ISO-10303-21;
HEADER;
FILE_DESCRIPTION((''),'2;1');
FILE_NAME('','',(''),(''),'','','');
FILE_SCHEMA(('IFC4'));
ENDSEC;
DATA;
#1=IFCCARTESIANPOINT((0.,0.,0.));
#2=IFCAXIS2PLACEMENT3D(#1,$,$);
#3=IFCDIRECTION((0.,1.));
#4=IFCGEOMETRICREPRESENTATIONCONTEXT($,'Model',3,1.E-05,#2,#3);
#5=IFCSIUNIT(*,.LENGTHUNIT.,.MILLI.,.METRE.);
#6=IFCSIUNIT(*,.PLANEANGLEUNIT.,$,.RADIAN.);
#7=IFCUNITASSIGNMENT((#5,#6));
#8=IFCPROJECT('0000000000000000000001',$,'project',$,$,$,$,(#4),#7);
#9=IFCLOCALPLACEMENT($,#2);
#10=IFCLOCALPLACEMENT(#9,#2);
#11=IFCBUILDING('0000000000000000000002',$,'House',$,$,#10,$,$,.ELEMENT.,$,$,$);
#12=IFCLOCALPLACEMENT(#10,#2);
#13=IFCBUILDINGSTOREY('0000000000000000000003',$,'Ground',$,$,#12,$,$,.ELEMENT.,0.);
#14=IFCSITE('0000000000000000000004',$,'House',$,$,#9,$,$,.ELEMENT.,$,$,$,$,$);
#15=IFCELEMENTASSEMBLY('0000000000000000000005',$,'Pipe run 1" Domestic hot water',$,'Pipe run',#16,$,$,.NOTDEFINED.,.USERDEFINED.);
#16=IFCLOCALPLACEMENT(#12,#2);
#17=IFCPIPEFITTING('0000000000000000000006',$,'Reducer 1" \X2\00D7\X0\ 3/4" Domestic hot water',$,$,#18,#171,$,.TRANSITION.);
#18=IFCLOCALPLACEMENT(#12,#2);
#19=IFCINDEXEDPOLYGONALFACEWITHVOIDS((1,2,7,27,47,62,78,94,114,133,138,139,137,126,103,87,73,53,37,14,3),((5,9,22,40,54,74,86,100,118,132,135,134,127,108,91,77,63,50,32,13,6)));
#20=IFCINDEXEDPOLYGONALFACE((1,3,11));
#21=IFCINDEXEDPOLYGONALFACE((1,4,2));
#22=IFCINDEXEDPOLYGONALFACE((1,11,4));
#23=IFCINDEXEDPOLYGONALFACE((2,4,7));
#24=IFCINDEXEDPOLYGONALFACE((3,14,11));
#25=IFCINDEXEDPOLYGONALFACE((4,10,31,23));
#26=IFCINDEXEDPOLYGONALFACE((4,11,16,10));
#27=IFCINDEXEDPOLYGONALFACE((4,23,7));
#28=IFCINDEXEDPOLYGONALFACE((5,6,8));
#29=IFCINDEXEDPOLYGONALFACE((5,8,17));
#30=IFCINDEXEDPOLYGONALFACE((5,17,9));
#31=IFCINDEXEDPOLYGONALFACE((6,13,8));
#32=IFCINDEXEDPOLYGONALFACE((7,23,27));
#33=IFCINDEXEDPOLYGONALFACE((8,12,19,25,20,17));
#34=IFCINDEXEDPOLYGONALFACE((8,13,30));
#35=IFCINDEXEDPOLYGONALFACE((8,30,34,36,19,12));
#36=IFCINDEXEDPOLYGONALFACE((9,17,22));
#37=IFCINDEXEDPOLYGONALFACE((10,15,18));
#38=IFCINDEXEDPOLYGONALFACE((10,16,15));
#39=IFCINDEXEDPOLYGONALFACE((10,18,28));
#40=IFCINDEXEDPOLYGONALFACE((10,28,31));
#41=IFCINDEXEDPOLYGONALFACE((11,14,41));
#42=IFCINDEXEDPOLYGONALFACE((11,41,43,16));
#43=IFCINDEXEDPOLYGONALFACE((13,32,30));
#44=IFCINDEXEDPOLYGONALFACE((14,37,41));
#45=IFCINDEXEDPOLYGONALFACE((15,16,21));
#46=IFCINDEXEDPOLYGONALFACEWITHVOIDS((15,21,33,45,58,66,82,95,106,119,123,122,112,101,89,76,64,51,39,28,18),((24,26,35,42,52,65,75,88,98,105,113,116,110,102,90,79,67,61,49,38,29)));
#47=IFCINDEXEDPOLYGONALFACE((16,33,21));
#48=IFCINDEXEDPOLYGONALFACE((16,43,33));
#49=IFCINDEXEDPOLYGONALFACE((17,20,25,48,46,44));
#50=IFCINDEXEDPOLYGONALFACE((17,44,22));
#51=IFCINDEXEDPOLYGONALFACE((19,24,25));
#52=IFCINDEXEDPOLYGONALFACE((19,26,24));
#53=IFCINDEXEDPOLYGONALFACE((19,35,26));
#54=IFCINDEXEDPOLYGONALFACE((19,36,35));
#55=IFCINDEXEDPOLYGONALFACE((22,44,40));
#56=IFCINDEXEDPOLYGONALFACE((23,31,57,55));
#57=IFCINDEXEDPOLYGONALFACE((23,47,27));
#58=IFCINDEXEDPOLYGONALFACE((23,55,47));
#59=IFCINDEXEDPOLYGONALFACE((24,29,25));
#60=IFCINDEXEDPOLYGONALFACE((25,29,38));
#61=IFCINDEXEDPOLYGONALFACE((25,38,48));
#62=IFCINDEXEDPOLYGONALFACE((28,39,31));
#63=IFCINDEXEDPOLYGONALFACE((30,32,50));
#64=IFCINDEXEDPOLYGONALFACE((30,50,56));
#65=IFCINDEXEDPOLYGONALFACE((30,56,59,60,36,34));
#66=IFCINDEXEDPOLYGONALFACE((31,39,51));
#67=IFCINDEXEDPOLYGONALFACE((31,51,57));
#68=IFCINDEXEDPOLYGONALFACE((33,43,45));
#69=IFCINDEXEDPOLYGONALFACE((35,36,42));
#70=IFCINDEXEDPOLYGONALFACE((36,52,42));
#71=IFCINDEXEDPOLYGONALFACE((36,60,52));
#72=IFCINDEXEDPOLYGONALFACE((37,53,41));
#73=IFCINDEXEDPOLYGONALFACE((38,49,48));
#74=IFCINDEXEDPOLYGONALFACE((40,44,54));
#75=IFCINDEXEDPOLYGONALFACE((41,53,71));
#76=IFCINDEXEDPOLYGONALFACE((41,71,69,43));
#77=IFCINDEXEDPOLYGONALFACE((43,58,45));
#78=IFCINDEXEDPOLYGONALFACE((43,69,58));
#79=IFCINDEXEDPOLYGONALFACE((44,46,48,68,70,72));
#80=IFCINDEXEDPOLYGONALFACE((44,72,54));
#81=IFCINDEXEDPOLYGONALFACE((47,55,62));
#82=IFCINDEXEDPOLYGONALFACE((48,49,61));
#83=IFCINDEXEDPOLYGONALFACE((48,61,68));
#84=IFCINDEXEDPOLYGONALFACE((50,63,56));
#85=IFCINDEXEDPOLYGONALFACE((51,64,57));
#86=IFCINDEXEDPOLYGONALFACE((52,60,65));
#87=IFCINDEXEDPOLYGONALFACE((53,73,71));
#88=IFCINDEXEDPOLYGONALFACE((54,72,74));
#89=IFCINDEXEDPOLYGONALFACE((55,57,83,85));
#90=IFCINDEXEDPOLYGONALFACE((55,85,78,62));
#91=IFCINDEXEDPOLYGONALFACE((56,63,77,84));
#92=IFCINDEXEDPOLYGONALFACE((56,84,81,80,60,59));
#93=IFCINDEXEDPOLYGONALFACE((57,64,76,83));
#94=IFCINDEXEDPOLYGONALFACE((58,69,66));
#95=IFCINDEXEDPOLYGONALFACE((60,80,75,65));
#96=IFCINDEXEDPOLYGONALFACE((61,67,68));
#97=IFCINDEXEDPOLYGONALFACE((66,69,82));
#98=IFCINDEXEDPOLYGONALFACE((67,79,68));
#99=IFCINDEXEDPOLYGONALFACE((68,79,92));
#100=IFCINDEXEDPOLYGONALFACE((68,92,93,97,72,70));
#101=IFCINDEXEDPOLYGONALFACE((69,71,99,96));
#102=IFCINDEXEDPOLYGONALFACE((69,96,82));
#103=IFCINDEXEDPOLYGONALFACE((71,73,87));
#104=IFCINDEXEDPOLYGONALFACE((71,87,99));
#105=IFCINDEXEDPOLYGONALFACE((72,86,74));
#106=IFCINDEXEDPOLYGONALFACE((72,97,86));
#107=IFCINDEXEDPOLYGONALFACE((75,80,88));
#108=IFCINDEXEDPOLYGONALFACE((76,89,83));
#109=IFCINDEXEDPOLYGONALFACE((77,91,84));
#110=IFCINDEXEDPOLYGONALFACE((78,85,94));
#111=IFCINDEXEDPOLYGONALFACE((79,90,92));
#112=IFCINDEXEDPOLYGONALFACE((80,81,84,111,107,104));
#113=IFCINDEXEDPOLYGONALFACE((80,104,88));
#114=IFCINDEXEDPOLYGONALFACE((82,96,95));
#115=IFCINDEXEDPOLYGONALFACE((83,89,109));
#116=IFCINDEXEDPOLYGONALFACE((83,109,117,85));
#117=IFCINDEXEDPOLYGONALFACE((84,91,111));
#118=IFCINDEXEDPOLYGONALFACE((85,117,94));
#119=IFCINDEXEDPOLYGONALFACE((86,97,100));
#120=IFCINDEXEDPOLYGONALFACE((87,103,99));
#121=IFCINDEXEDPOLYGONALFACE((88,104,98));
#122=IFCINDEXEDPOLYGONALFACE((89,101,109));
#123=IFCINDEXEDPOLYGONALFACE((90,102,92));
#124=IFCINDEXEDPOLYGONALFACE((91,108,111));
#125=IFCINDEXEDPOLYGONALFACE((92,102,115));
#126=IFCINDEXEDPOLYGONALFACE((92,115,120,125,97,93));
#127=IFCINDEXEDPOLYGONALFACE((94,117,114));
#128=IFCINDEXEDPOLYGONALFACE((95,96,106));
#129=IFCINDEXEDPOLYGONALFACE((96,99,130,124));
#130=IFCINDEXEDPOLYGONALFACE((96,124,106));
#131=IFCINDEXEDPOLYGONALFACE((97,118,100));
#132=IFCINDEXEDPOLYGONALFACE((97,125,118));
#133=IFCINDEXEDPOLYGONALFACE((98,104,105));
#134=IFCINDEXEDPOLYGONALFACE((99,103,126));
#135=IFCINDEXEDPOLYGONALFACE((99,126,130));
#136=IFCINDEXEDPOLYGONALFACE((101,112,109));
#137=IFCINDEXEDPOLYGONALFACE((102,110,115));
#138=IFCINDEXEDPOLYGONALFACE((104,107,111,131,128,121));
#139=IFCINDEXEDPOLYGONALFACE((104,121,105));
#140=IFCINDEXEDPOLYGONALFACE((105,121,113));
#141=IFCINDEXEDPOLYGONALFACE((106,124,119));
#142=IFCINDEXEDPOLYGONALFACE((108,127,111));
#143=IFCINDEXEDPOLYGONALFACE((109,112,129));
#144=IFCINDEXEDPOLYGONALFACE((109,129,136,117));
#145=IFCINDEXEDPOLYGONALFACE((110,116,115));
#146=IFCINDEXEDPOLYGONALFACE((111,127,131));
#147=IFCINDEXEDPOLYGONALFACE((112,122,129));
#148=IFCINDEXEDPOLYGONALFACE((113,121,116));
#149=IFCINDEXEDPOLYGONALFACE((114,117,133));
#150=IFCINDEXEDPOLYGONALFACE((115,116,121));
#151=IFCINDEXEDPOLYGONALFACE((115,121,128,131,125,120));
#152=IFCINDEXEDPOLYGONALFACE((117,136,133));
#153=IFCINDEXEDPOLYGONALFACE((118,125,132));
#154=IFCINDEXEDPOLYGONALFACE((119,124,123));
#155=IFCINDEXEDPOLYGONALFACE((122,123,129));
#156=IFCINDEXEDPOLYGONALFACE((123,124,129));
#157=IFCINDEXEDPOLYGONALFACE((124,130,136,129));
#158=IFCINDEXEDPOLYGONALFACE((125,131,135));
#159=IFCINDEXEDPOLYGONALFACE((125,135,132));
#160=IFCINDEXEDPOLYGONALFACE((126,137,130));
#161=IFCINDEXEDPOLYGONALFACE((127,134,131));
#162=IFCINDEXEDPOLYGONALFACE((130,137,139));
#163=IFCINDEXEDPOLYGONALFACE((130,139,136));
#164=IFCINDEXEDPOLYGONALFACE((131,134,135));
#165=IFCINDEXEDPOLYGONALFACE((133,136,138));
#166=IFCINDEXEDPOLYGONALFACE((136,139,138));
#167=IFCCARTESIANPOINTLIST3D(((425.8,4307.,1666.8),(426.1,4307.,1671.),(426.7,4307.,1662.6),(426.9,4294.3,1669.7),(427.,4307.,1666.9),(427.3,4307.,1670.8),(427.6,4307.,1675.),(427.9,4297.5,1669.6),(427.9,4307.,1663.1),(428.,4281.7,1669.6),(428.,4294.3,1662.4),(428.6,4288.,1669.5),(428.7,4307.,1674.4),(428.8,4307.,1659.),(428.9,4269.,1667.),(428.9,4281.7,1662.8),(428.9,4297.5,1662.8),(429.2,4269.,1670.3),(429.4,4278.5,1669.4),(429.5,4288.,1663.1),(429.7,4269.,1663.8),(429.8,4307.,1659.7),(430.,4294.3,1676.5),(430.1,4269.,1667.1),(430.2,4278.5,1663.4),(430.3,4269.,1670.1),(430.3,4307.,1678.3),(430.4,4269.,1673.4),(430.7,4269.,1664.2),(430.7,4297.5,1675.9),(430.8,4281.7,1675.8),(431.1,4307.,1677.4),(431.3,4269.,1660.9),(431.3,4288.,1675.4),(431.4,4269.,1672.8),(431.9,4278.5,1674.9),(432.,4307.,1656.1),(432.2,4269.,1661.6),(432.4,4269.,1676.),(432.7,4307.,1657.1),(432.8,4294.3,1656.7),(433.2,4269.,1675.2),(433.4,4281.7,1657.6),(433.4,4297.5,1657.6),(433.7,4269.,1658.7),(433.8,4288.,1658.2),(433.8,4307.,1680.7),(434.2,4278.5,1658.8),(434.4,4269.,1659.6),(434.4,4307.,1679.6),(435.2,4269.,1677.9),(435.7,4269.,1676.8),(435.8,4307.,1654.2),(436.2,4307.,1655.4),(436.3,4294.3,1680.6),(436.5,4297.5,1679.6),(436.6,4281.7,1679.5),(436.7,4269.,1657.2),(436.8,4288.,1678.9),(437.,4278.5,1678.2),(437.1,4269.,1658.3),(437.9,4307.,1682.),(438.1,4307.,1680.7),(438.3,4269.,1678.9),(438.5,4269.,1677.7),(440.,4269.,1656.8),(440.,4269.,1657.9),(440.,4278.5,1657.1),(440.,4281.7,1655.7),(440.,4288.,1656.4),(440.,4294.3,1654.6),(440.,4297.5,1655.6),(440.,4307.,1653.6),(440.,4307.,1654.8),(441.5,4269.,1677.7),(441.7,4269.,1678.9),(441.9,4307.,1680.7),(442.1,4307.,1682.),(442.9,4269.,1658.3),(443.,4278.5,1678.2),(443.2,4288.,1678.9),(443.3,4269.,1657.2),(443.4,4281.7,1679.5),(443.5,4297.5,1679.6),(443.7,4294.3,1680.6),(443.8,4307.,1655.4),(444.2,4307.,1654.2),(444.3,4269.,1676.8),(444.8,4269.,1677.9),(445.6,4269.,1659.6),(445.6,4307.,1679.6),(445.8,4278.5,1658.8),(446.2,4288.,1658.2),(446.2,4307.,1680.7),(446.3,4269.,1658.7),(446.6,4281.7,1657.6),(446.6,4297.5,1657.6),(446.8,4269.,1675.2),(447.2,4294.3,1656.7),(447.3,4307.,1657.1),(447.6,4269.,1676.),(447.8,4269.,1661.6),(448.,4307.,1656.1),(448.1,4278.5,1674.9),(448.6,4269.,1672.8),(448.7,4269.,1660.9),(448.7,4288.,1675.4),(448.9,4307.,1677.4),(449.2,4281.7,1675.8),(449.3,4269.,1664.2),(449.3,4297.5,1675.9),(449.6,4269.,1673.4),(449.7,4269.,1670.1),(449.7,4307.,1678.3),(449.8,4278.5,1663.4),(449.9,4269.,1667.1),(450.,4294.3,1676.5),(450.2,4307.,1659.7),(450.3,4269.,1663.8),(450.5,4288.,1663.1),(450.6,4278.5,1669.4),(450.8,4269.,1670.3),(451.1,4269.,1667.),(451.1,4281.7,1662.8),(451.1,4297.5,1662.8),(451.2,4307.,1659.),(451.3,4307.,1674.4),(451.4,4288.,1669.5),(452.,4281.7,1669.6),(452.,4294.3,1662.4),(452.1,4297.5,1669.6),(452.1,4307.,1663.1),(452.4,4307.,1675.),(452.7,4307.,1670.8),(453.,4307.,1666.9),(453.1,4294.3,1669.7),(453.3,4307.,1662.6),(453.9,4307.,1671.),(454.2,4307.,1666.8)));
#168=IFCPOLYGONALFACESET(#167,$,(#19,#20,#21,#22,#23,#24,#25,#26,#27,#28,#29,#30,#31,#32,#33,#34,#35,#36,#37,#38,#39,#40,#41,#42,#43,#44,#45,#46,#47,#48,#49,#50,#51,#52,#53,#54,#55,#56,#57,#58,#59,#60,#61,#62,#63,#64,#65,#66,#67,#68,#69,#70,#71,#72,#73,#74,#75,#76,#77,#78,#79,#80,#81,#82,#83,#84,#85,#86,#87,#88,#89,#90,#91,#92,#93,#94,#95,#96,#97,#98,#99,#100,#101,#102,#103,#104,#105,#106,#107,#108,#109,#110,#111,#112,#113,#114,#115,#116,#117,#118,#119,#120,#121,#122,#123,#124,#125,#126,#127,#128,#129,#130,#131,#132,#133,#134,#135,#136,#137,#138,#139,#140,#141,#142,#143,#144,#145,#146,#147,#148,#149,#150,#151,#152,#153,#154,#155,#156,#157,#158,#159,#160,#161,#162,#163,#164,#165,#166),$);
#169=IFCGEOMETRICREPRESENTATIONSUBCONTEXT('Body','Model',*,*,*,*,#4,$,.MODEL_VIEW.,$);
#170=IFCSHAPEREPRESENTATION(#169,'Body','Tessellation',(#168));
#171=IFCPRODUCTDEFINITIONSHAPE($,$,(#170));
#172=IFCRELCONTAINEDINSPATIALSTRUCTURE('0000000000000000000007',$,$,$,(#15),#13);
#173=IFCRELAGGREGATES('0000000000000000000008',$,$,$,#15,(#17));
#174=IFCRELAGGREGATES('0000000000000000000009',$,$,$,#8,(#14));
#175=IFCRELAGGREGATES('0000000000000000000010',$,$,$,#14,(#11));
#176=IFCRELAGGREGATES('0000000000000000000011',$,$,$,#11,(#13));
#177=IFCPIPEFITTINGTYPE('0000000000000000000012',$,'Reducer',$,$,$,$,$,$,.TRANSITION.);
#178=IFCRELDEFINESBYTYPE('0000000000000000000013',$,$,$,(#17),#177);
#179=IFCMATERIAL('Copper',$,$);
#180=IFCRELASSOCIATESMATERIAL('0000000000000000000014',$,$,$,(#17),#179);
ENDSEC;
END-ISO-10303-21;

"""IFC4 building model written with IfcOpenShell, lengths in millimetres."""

from ifc_helpers import new_model, entity, si_unit, direction, origin, origin_with_axes, place, context, subcontext, project, spatial, material, type_object, element, aggregate, save


model = new_model("IFC4")

# Units and contexts
model_context = context("Model", 3, precision=1e-05, world=origin(), true_north=direction((0.0, 1.0)))
body_context = subcontext(model_context, "Body", "Model", "MODEL_VIEW")
ifc_project = project(units=[si_unit("LENGTHUNIT", "METRE", prefix="MILLI"), si_unit("PLANEANGLEUNIT", "RADIAN")], contexts=[model_context])

# Site, building, storey
site_placement = place(None, origin())
site = spatial("IfcSite", under=ifc_project, at=site_placement, Name="House", CompositionType="ELEMENT")
building_placement = place(site_placement, origin())
building = spatial("IfcBuilding", under=site, at=building_placement, Name="House", CompositionType="ELEMENT")
storey_placement = place(building_placement, origin())
storey = spatial("IfcBuildingStorey", under=building, at=storey_placement, Name="Ground", CompositionType="ELEMENT", Elevation=0.0)

# Element assembly
assembly_1_placement = place(storey_placement, origin_with_axes())
assembly_1 = element("IfcElementAssembly", 1, at=assembly_1_placement, inside=storey, Name="Pipe run 1\" Domestic hot water", ObjectType="Pipe run", AssemblyPlace="NOTDEFINED", PredefinedType="USERDEFINED")
ifc_material = material(Name="Copper")

# Pipe fitting
pipe_fitting_type_1 = type_object("IfcPipeFittingType", Name="Reducer", PredefinedType="TRANSITION")
pipe_fitting_1_placement = place(storey_placement, origin_with_axes())
cartesian_point = entity("IfcCartesianPoint", [0.0, 13.0])
pipe_fitting_1 = element("IfcPipeFitting", 2, at=pipe_fitting_1_placement, type_object=pipe_fitting_type_1, material=ifc_material, Name="Reducer 1\" × 3/4\" Domestic hot water", PredefinedType="TRANSITION", context=body_context, shape_type="SweptSolid", body=[
    entity("IfcRevolvedAreaSolid", entity("IfcArbitraryClosedProfileDef", "AREA", None, entity("IfcPolyline", [cartesian_point, entity("IfcCartesianPoint", [0.0, 14.3]), entity("IfcCartesianPoint", [38.0, 11.1]), entity("IfcCartesianPoint", [38.0, 10.0]), cartesian_point])), entity("IfcAxis2Placement3D", entity("IfcCartesianPoint", [440.0, 4307.0, 1667.9]), entity("IfcDirection", [1.0, 0.0, 0.0]), entity("IfcDirection", [0.0, -1.0, 0.0])), entity("IfcAxis1Placement", entity("IfcCartesianPoint", [0.0, 0.0, 0.0]), entity("IfcDirection", [1.0, 0.0, 0.0])), 6.283185),
])
aggregate(assembly_1, [pipe_fitting_1])

save(model, "model.ifc")
